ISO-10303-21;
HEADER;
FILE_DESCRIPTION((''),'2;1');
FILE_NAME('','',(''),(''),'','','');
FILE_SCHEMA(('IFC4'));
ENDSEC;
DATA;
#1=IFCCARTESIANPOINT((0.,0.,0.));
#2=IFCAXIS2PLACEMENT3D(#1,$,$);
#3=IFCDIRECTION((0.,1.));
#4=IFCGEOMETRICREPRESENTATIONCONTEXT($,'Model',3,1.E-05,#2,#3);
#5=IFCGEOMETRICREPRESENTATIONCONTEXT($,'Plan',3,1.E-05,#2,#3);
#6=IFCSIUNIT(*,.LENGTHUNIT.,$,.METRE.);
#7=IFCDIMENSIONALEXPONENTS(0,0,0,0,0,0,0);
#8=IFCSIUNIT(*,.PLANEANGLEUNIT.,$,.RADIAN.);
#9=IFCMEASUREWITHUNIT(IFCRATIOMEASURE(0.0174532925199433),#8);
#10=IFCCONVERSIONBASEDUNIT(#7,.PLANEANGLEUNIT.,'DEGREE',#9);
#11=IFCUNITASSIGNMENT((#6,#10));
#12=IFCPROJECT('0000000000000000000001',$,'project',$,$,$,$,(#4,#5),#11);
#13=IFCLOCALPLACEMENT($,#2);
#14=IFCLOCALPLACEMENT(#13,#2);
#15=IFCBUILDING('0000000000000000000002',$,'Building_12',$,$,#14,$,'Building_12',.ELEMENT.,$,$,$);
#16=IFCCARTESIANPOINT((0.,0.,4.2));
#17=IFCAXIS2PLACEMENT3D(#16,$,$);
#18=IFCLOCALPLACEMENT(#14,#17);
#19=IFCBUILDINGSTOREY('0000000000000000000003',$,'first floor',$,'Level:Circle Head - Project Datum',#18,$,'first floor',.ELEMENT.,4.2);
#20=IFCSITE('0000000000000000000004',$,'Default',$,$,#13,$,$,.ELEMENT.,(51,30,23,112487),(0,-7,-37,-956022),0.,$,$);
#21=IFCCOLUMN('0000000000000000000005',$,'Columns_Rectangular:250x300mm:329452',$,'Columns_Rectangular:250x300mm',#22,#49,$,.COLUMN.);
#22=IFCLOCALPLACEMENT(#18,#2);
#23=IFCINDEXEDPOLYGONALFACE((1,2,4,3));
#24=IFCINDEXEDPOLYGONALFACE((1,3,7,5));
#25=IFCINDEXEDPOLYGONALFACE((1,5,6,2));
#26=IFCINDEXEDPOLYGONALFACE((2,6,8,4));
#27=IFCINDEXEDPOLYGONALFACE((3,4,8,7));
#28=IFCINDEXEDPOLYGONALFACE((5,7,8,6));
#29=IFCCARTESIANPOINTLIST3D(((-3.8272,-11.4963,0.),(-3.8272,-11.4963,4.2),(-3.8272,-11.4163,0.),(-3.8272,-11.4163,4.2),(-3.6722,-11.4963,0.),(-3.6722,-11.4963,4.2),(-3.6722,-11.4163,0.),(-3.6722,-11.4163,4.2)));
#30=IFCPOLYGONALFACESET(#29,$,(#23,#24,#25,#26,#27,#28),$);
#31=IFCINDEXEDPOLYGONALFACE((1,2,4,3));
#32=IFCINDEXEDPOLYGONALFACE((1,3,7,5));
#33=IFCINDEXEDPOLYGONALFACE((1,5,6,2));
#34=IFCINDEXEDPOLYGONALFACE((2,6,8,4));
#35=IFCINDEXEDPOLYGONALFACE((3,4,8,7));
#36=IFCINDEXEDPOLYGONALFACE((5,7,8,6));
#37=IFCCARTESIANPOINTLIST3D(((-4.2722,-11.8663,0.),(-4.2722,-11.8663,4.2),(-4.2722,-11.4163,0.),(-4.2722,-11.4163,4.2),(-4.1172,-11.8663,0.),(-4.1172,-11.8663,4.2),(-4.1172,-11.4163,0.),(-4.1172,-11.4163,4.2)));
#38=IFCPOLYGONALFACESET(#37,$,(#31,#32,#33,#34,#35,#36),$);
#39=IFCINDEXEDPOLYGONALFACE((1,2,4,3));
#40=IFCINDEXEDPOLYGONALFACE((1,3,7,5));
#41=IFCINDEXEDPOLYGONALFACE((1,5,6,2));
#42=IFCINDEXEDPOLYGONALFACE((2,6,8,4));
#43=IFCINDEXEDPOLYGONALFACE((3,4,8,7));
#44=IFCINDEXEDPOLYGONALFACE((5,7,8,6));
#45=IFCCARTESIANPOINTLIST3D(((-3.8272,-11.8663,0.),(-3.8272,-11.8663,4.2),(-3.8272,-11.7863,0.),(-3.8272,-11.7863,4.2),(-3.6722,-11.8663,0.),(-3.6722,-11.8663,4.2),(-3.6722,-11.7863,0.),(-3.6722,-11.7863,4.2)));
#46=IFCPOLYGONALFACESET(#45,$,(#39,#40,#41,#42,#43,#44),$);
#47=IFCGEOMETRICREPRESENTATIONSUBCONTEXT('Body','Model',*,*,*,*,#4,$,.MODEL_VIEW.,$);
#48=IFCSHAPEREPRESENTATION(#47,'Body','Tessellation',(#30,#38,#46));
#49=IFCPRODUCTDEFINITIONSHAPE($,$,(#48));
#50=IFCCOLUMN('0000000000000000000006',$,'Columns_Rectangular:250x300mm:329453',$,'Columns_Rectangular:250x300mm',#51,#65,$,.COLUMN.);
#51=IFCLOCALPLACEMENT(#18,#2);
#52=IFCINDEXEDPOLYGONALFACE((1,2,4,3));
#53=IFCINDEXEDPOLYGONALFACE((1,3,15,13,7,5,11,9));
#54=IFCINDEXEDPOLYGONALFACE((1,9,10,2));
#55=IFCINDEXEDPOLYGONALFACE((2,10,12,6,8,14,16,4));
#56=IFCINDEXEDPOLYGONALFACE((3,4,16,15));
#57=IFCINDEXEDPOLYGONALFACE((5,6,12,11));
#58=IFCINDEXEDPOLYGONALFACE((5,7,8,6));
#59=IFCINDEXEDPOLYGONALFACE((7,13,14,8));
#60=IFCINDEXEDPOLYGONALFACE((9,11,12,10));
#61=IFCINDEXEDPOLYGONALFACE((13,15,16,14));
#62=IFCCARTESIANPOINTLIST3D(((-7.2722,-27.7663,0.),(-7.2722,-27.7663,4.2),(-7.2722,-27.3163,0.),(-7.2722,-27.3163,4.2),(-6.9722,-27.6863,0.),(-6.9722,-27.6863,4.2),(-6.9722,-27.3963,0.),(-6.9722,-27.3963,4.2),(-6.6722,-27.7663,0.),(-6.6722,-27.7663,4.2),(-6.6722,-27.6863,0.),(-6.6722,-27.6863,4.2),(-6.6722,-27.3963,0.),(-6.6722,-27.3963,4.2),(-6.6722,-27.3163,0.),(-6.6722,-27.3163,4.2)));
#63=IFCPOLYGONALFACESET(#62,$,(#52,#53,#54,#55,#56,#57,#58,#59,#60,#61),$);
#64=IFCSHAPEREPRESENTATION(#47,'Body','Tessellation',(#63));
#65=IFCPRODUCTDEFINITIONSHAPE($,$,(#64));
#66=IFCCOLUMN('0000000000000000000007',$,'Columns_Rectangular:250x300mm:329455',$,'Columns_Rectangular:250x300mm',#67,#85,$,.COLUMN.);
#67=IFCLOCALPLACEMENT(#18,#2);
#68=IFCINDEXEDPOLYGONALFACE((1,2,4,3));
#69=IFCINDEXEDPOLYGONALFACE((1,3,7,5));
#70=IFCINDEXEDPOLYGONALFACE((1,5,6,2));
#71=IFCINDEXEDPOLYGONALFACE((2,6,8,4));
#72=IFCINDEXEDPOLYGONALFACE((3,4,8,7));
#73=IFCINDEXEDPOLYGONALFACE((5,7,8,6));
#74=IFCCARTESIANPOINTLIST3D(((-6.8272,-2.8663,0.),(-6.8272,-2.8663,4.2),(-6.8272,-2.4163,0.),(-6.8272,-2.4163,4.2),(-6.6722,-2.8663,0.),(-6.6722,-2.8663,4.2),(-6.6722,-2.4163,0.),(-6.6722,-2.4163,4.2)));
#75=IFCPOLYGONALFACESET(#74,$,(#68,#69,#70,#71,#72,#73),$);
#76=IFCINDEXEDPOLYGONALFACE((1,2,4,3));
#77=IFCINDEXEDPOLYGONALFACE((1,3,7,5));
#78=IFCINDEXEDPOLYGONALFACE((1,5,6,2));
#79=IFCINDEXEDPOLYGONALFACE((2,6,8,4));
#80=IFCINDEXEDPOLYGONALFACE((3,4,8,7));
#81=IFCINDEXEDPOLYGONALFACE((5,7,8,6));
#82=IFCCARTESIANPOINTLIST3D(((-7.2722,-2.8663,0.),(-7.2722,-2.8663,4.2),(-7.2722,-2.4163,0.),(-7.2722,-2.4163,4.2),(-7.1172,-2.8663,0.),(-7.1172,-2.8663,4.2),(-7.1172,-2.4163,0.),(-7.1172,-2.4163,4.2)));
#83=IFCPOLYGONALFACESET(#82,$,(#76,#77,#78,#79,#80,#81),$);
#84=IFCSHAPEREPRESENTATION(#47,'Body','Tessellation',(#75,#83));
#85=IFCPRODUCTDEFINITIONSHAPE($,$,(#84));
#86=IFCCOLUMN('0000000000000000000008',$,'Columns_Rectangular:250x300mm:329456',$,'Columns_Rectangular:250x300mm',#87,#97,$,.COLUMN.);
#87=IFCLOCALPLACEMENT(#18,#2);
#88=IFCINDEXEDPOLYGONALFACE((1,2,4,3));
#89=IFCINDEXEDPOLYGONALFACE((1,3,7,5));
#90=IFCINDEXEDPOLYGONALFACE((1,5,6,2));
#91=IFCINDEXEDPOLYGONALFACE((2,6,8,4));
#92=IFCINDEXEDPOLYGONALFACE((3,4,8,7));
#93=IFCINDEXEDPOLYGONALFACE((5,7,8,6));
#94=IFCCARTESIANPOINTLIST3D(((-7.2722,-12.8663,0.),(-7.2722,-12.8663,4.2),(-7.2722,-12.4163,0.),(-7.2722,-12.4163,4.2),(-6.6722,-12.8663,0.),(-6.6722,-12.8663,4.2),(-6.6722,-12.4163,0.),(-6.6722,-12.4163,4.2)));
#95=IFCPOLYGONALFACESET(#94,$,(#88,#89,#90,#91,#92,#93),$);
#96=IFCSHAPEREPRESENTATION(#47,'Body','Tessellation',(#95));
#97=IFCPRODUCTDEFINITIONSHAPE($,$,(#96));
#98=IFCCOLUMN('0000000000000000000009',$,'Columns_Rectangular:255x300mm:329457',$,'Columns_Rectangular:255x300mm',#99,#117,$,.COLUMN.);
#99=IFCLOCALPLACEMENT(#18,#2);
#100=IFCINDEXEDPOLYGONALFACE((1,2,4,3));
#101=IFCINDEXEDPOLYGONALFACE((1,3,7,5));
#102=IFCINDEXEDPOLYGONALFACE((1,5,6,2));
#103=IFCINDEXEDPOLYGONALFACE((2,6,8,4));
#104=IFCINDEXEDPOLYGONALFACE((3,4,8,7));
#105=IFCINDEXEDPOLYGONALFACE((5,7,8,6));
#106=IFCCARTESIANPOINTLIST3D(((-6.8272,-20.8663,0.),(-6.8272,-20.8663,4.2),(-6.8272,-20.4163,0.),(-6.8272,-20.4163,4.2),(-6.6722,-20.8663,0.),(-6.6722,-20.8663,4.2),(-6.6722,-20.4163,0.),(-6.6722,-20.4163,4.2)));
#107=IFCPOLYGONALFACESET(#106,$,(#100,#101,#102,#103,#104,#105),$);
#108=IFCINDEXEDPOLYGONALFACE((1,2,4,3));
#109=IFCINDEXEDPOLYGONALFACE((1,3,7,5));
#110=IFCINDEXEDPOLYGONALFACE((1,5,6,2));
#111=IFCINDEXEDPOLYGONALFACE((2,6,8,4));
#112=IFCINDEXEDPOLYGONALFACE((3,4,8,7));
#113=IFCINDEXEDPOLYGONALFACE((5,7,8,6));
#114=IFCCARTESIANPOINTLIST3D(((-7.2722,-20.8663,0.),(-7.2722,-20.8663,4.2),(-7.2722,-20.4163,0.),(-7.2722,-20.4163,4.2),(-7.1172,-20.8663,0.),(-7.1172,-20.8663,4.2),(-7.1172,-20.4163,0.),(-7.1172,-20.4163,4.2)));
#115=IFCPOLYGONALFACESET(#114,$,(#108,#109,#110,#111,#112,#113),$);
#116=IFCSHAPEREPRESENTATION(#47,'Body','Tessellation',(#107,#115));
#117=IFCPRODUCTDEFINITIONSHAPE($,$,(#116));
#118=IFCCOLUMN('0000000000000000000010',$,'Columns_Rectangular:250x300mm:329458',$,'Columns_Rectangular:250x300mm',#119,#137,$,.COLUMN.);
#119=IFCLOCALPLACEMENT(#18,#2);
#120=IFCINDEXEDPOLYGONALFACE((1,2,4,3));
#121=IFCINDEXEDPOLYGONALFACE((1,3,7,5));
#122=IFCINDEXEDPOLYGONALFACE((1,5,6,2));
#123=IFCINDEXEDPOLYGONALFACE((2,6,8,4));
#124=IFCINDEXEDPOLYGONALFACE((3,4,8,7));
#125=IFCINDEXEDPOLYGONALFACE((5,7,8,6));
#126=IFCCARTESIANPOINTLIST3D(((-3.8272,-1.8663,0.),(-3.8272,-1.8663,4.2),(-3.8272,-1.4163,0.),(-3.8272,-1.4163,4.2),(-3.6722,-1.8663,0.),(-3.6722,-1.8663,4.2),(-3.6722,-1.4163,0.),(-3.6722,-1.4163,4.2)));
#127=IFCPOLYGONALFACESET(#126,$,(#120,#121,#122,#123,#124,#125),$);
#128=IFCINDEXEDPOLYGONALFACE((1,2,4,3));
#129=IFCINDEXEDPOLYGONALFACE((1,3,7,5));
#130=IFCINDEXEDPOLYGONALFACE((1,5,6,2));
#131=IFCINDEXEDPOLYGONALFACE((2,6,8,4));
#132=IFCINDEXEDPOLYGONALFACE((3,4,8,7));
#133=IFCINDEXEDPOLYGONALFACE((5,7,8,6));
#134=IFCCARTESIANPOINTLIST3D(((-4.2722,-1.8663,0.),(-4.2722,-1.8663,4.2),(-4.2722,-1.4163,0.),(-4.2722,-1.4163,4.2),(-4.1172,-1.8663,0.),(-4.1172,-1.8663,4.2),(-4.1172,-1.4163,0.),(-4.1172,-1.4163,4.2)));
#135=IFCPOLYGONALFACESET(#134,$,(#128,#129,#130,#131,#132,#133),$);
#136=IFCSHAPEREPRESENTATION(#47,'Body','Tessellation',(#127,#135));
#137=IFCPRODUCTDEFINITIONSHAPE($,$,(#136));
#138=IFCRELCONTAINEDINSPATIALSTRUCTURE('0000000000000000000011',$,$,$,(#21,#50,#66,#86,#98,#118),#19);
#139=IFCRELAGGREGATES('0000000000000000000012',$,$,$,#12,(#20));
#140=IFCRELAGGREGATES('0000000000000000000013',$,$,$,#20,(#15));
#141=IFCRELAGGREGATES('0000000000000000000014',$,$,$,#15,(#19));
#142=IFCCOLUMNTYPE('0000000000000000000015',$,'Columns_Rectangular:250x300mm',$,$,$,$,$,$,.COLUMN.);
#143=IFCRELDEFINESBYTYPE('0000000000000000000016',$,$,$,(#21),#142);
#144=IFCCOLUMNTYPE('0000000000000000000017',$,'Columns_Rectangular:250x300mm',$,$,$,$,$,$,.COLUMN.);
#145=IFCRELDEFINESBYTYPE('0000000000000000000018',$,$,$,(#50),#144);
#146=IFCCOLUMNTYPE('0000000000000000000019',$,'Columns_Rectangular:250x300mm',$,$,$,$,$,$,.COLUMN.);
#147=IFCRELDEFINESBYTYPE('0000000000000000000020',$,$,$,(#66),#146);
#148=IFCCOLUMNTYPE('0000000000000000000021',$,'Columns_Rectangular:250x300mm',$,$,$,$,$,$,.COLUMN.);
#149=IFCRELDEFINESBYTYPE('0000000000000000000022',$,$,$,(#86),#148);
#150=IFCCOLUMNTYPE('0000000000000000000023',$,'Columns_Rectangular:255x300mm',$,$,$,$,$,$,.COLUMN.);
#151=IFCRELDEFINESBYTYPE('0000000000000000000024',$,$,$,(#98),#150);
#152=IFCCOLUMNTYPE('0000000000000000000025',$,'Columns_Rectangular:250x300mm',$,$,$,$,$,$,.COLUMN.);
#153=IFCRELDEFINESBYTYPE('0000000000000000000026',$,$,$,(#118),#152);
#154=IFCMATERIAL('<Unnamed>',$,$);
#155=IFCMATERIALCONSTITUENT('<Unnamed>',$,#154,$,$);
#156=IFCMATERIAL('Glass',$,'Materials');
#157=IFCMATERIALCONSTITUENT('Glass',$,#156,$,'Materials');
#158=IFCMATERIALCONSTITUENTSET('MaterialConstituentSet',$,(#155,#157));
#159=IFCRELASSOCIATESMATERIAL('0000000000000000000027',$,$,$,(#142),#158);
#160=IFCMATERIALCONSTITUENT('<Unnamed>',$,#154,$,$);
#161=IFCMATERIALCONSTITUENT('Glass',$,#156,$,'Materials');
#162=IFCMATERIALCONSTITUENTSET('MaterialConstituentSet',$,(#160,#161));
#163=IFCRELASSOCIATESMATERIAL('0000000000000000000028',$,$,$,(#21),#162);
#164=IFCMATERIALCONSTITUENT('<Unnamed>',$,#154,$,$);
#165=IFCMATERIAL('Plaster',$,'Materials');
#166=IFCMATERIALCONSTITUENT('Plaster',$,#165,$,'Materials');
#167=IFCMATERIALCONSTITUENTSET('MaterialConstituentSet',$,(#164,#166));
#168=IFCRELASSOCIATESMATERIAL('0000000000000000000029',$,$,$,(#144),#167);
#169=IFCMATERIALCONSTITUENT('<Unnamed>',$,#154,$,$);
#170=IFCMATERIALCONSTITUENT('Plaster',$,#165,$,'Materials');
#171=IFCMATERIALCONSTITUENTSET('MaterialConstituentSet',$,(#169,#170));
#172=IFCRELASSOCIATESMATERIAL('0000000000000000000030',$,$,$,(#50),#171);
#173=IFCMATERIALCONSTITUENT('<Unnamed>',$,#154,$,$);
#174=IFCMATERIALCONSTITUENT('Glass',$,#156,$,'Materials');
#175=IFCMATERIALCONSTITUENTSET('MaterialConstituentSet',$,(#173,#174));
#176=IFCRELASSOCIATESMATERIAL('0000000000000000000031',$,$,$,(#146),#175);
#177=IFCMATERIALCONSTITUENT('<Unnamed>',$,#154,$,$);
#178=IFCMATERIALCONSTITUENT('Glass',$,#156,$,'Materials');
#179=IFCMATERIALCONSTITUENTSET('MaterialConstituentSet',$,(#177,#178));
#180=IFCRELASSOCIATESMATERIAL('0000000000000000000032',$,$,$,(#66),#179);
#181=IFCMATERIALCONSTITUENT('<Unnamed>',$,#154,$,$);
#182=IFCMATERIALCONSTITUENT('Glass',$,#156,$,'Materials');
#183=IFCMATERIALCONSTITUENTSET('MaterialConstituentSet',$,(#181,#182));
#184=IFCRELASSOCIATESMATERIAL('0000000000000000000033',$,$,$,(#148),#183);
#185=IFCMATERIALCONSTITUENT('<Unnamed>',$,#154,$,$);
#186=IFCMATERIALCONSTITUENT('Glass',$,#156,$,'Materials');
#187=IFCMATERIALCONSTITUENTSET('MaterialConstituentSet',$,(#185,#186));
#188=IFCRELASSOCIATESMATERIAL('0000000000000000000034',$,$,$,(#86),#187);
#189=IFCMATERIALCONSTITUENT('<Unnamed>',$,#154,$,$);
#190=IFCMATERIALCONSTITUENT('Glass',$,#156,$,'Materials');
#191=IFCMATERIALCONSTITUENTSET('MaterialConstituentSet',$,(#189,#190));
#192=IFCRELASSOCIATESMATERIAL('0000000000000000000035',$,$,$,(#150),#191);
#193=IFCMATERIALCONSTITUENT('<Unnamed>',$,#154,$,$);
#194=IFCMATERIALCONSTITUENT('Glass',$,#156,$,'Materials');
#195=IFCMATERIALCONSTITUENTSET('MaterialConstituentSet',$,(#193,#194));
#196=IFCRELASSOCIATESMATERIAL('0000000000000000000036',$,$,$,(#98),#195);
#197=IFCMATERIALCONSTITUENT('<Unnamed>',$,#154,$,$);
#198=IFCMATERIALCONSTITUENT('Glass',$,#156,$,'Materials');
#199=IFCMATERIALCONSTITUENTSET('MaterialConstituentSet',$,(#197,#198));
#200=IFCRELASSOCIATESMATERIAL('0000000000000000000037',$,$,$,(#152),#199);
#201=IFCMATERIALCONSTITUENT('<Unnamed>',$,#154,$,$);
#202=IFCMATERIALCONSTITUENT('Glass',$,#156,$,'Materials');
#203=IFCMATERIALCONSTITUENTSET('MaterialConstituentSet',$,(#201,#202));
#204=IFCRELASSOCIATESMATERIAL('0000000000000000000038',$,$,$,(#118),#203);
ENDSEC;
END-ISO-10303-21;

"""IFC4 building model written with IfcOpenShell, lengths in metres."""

from ifc_helpers import new_model, entity, si_unit, converted_unit, direction, frame, origin, place, context, subcontext, project, spatial, indexed_curve, outline, extrude, source, transform, mapped, material, constituent, constituent_set, type_object, type_shapes, element, save


model = new_model("IFC4")

# Units and contexts
model_context = context("Model", 3, precision=1e-05, world=origin(), true_north=direction((0.0, 1.0)))
plan_context = context("Plan", 3, precision=1e-05, world=origin(), true_north=direction((0.0, 1.0)))
body_context = subcontext(model_context, "Body", "Model", "MODEL_VIEW")
ifc_project = project(units=[si_unit("LENGTHUNIT", "METRE"), converted_unit("PLANEANGLEUNIT", "DEGREE", entity("IfcRatioMeasure", 0.0174532925199433), si_unit("PLANEANGLEUNIT", "RADIAN"), dimensions=[0, 0, 0, 0, 0, 0, 0])], contexts=[model_context, plan_context])

# Site, building, storey
site_placement = place(None, origin())
site = spatial("IfcSite", under=ifc_project, at=site_placement, Name="Default", CompositionType="ELEMENT", RefLatitude=(51, 30, 23, 112487), RefLongitude=(0, -7, -37, -956022), RefElevation=0.0)
building_placement = place(site_placement, origin())
building = spatial("IfcBuilding", under=site, at=building_placement, Name="Building_12", LongName="Building_12", CompositionType="ELEMENT")
storey_placement = place(building_placement, frame((0.0, 0.0, 4.2)))
storey = spatial("IfcBuildingStorey", under=building, at=storey_placement, Name="first floor", ObjectType="Level:Circle Head - Project Datum", LongName="first floor", CompositionType="ELEMENT", Elevation=4.2)

# Columns
ifc_material_1 = material(Name="<Unnamed>")
ifc_material_2 = material(Name="Plaster", Category="Materials")
ifc_constituent_1 = constituent(ifc_material_1, Name="<Unnamed>")
ifc_material_3 = material(Name="Glass", Category="Materials")
ifc_constituent_2 = constituent(ifc_material_3, Name="Glass", Category="Materials")
ifc_constituent_set_1 = constituent_set(constituents=[ifc_constituent_1, ifc_constituent_2], Name="MaterialConstituentSet")
ifc_constituent_3 = constituent(ifc_material_1, Name="<Unnamed>")
ifc_constituent_4 = constituent(ifc_material_3, Name="Glass", Category="Materials")
ifc_constituent_set_2 = constituent_set(constituents=[ifc_constituent_3, ifc_constituent_4], Name="MaterialConstituentSet")
column_type_1 = type_object("IfcColumnType", Name="Columns_Rectangular:250x300mm", PredefinedType="COLUMN", material=ifc_constituent_set_2)
shared_shape_1 = source(origin(), body_context, "Body", "SweptSolid", [
    extrude(outline(indexed_curve([(-0.04, -0.0775), (0.04, -0.0775), (0.04, 0.0775), (-0.04, 0.0775), (-0.04, -0.0775)], self_intersect=False)), frame((-3.7497, -11.4563, 4.2), z_axis=(0.0, 0.0, 1.0), x_axis=(0.0, -1.0, 0.0)), (0.0, 0.0, 1.0), 4.2),
    extrude(outline(indexed_curve([(-0.225, -0.0775), (0.225, -0.0775), (0.225, 0.0775), (-0.225, 0.0775), (-0.225, -0.0775)], self_intersect=False)), frame((-4.1947, -11.6413, 4.2), z_axis=(0.0, 0.0, 1.0), x_axis=(0.0, -1.0, 0.0)), (0.0, 0.0, 1.0), 4.2),
    extrude(outline(indexed_curve([(-0.04, -0.0775), (0.04, -0.0775), (0.04, 0.0775), (-0.04, 0.0775), (-0.04, -0.0775)], self_intersect=False)), frame((-3.7497, -11.8263, 4.2), z_axis=(0.0, 0.0, 1.0), x_axis=(0.0, -1.0, 0.0)), (0.0, 0.0, 1.0), 4.2),
])
type_shapes(column_type_1, [shared_shape_1])
column_1_placement = place(storey_placement, frame((0.0, 0.0, -4.2)))
element("IfcColumn", 1, at=column_1_placement, inside=storey, type_object=column_type_1, material=ifc_constituent_set_1, Name="Columns_Rectangular:250x300mm:329452", ObjectType="Columns_Rectangular:250x300mm", PredefinedType="COLUMN", context=body_context, shape_type="MappedRepresentation", body=[
    mapped(shared_shape_1, transform((0.0, 0.0, 0.0), scale=1.0)),
])
ifc_constituent_5 = constituent(ifc_material_1, Name="<Unnamed>")
ifc_constituent_6 = constituent(ifc_material_2, Name="Plaster", Category="Materials")
ifc_constituent_set_3 = constituent_set(constituents=[ifc_constituent_5, ifc_constituent_6], Name="MaterialConstituentSet")
ifc_constituent_7 = constituent(ifc_material_1, Name="<Unnamed>")
ifc_constituent_8 = constituent(ifc_material_2, Name="Plaster", Category="Materials")
ifc_constituent_set_4 = constituent_set(constituents=[ifc_constituent_7, ifc_constituent_8], Name="MaterialConstituentSet")
column_type_2 = type_object("IfcColumnType", Name="Columns_Rectangular:250x300mm", PredefinedType="COLUMN", material=ifc_constituent_set_4)
shared_shape_2 = source(origin(), body_context, "Body", "SweptSolid", [
    extrude(outline(indexed_curve([(-0.225, -0.375), (0.225, -0.375), (0.225, 0.225), (0.145, 0.225), (0.145, -0.075), (-0.145, -0.075), (-0.145, 0.225), (-0.225, 0.225), (-0.225, -0.375)], self_intersect=False)), frame((-6.8972, -27.5413, 4.2), z_axis=(0.0, 0.0, 1.0), x_axis=(0.0, -1.0, 0.0)), (0.0, 0.0, 1.0), 4.2),
])
type_shapes(column_type_2, [shared_shape_2])
column_2_placement = place(storey_placement, frame((0.0, 0.0, -4.2)))
element("IfcColumn", 2, at=column_2_placement, inside=storey, type_object=column_type_2, material=ifc_constituent_set_3, Name="Columns_Rectangular:250x300mm:329453", ObjectType="Columns_Rectangular:250x300mm", PredefinedType="COLUMN", context=body_context, shape_type="MappedRepresentation", body=[
    mapped(shared_shape_2, transform((0.0, 0.0, 0.0), scale=1.0)),
])
ifc_constituent_9 = constituent(ifc_material_1, Name="<Unnamed>")
ifc_constituent_10 = constituent(ifc_material_3, Name="Glass", Category="Materials")
ifc_constituent_set_5 = constituent_set(constituents=[ifc_constituent_9, ifc_constituent_10], Name="MaterialConstituentSet")
ifc_constituent_11 = constituent(ifc_material_1, Name="<Unnamed>")
ifc_constituent_12 = constituent(ifc_material_3, Name="Glass", Category="Materials")
ifc_constituent_set_6 = constituent_set(constituents=[ifc_constituent_11, ifc_constituent_12], Name="MaterialConstituentSet")
column_type_3 = type_object("IfcColumnType", Name="Columns_Rectangular:250x300mm", PredefinedType="COLUMN", material=ifc_constituent_set_6)
shared_shape_3 = source(origin(), body_context, "Body", "SweptSolid", [
    extrude(outline(indexed_curve([(-0.225, -0.0775), (0.225, -0.0775), (0.225, 0.0775), (-0.225, 0.0775), (-0.225, -0.0775)], self_intersect=False)), frame((-6.7497, -2.6413, 4.2), z_axis=(0.0, 0.0, 1.0), x_axis=(0.0, -1.0, 0.0)), (0.0, 0.0, 1.0), 4.2),
    extrude(outline(indexed_curve([(-0.225, -0.0775), (0.225, -0.0775), (0.225, 0.0775), (-0.225, 0.0775), (-0.225, -0.0775)], self_intersect=False)), frame((-7.1947, -2.6413, 4.2), z_axis=(0.0, 0.0, 1.0), x_axis=(0.0, -1.0, 0.0)), (0.0, 0.0, 1.0), 4.2),
])
type_shapes(column_type_3, [shared_shape_3])
column_3_placement = place(storey_placement, frame((0.0, 0.0, -4.2)))
element("IfcColumn", 3, at=column_3_placement, inside=storey, type_object=column_type_3, material=ifc_constituent_set_5, Name="Columns_Rectangular:250x300mm:329455", ObjectType="Columns_Rectangular:250x300mm", PredefinedType="COLUMN", context=body_context, shape_type="MappedRepresentation", body=[
    mapped(shared_shape_3, transform((0.0, 0.0, 0.0), scale=1.0)),
])
ifc_constituent_13 = constituent(ifc_material_1, Name="<Unnamed>")
ifc_constituent_14 = constituent(ifc_material_3, Name="Glass", Category="Materials")
ifc_constituent_set_7 = constituent_set(constituents=[ifc_constituent_13, ifc_constituent_14], Name="MaterialConstituentSet")
ifc_constituent_15 = constituent(ifc_material_1, Name="<Unnamed>")
ifc_constituent_16 = constituent(ifc_material_3, Name="Glass", Category="Materials")
ifc_constituent_set_8 = constituent_set(constituents=[ifc_constituent_15, ifc_constituent_16], Name="MaterialConstituentSet")
column_type_4 = type_object("IfcColumnType", Name="Columns_Rectangular:250x300mm", PredefinedType="COLUMN", material=ifc_constituent_set_8)
shared_shape_4 = source(origin(), body_context, "Body", "SweptSolid", [
    extrude(outline(indexed_curve([(-0.225, -0.3), (0.225, -0.3), (0.225, 0.3), (-0.225, 0.3), (-0.225, -0.3)], self_intersect=False)), frame((-6.9722, -12.6413, 4.2), z_axis=(0.0, 0.0, 1.0), x_axis=(0.0, -1.0, 0.0)), (0.0, 0.0, 1.0), 4.2),
])
type_shapes(column_type_4, [shared_shape_4])
column_4_placement = place(storey_placement, frame((0.0, 0.0, -4.2)))
element("IfcColumn", 4, at=column_4_placement, inside=storey, type_object=column_type_4, material=ifc_constituent_set_7, Name="Columns_Rectangular:250x300mm:329456", ObjectType="Columns_Rectangular:250x300mm", PredefinedType="COLUMN", context=body_context, shape_type="MappedRepresentation", body=[
    mapped(shared_shape_4, transform((0.0, 0.0, 0.0), scale=1.0)),
])
ifc_constituent_17 = constituent(ifc_material_1, Name="<Unnamed>")
ifc_constituent_18 = constituent(ifc_material_3, Name="Glass", Category="Materials")
ifc_constituent_set_9 = constituent_set(constituents=[ifc_constituent_17, ifc_constituent_18], Name="MaterialConstituentSet")
ifc_constituent_19 = constituent(ifc_material_1, Name="<Unnamed>")
ifc_constituent_20 = constituent(ifc_material_3, Name="Glass", Category="Materials")
ifc_constituent_set_10 = constituent_set(constituents=[ifc_constituent_19, ifc_constituent_20], Name="MaterialConstituentSet")
column_type_5 = type_object("IfcColumnType", Name="Columns_Rectangular:255x300mm", PredefinedType="COLUMN", material=ifc_constituent_set_10)
shared_shape_5 = source(origin(), body_context, "Body", "SweptSolid", [
    extrude(outline(indexed_curve([(-0.225, -0.0775), (0.225, -0.0775), (0.225, 0.0775), (-0.225, 0.0775), (-0.225, -0.0775)], self_intersect=False)), frame((-6.7497, -20.6413, 4.2), z_axis=(0.0, 0.0, 1.0), x_axis=(0.0, -1.0, 0.0)), (0.0, 0.0, 1.0), 4.2),
    extrude(outline(indexed_curve([(-0.225, -0.0775), (0.225, -0.0775), (0.225, 0.0775), (-0.225, 0.0775), (-0.225, -0.0775)], self_intersect=False)), frame((-7.1947, -20.6413, 4.2), z_axis=(0.0, 0.0, 1.0), x_axis=(0.0, -1.0, 0.0)), (0.0, 0.0, 1.0), 4.2),
])
type_shapes(column_type_5, [shared_shape_5])
column_5_placement = place(storey_placement, frame((0.0, 0.0, -4.2)))
element("IfcColumn", 5, at=column_5_placement, inside=storey, type_object=column_type_5, material=ifc_constituent_set_9, Name="Columns_Rectangular:255x300mm:329457", ObjectType="Columns_Rectangular:255x300mm", PredefinedType="COLUMN", context=body_context, shape_type="MappedRepresentation", body=[
    mapped(shared_shape_5, transform((0.0, 0.0, 0.0), scale=1.0)),
])
ifc_constituent_21 = constituent(ifc_material_1, Name="<Unnamed>")
ifc_constituent_22 = constituent(ifc_material_3, Name="Glass", Category="Materials")
ifc_constituent_set_11 = constituent_set(constituents=[ifc_constituent_21, ifc_constituent_22], Name="MaterialConstituentSet")
ifc_constituent_23 = constituent(ifc_material_1, Name="<Unnamed>")
ifc_constituent_24 = constituent(ifc_material_3, Name="Glass", Category="Materials")
ifc_constituent_set_12 = constituent_set(constituents=[ifc_constituent_23, ifc_constituent_24], Name="MaterialConstituentSet")
column_type_6 = type_object("IfcColumnType", Name="Columns_Rectangular:250x300mm", PredefinedType="COLUMN", material=ifc_constituent_set_12)
shared_shape_6 = source(origin(), body_context, "Body", "SweptSolid", [
    extrude(outline(indexed_curve([(-0.225, -0.0775), (0.225, -0.0775), (0.225, 0.0775), (-0.225, 0.0775), (-0.225, -0.0775)], self_intersect=False)), frame((-3.7497, -1.6413, 4.2), z_axis=(0.0, 0.0, 1.0), x_axis=(0.0, -1.0, 0.0)), (0.0, 0.0, 1.0), 4.2),
    extrude(outline(indexed_curve([(-0.225, -0.0775), (0.225, -0.0775), (0.225, 0.0775), (-0.225, 0.0775), (-0.225, -0.0775)], self_intersect=False)), frame((-4.1947, -1.6413, 4.2), z_axis=(0.0, 0.0, 1.0), x_axis=(0.0, -1.0, 0.0)), (0.0, 0.0, 1.0), 4.2),
])
type_shapes(column_type_6, [shared_shape_6])
column_6_placement = place(storey_placement, frame((0.0, 0.0, -4.2)))
element("IfcColumn", 6, at=column_6_placement, inside=storey, type_object=column_type_6, material=ifc_constituent_set_11, Name="Columns_Rectangular:250x300mm:329458", ObjectType="Columns_Rectangular:250x300mm", PredefinedType="COLUMN", context=body_context, shape_type="MappedRepresentation", body=[
    mapped(shared_shape_6, transform((0.0, 0.0, 0.0), scale=1.0)),
])

save(model, "model.ifc")
